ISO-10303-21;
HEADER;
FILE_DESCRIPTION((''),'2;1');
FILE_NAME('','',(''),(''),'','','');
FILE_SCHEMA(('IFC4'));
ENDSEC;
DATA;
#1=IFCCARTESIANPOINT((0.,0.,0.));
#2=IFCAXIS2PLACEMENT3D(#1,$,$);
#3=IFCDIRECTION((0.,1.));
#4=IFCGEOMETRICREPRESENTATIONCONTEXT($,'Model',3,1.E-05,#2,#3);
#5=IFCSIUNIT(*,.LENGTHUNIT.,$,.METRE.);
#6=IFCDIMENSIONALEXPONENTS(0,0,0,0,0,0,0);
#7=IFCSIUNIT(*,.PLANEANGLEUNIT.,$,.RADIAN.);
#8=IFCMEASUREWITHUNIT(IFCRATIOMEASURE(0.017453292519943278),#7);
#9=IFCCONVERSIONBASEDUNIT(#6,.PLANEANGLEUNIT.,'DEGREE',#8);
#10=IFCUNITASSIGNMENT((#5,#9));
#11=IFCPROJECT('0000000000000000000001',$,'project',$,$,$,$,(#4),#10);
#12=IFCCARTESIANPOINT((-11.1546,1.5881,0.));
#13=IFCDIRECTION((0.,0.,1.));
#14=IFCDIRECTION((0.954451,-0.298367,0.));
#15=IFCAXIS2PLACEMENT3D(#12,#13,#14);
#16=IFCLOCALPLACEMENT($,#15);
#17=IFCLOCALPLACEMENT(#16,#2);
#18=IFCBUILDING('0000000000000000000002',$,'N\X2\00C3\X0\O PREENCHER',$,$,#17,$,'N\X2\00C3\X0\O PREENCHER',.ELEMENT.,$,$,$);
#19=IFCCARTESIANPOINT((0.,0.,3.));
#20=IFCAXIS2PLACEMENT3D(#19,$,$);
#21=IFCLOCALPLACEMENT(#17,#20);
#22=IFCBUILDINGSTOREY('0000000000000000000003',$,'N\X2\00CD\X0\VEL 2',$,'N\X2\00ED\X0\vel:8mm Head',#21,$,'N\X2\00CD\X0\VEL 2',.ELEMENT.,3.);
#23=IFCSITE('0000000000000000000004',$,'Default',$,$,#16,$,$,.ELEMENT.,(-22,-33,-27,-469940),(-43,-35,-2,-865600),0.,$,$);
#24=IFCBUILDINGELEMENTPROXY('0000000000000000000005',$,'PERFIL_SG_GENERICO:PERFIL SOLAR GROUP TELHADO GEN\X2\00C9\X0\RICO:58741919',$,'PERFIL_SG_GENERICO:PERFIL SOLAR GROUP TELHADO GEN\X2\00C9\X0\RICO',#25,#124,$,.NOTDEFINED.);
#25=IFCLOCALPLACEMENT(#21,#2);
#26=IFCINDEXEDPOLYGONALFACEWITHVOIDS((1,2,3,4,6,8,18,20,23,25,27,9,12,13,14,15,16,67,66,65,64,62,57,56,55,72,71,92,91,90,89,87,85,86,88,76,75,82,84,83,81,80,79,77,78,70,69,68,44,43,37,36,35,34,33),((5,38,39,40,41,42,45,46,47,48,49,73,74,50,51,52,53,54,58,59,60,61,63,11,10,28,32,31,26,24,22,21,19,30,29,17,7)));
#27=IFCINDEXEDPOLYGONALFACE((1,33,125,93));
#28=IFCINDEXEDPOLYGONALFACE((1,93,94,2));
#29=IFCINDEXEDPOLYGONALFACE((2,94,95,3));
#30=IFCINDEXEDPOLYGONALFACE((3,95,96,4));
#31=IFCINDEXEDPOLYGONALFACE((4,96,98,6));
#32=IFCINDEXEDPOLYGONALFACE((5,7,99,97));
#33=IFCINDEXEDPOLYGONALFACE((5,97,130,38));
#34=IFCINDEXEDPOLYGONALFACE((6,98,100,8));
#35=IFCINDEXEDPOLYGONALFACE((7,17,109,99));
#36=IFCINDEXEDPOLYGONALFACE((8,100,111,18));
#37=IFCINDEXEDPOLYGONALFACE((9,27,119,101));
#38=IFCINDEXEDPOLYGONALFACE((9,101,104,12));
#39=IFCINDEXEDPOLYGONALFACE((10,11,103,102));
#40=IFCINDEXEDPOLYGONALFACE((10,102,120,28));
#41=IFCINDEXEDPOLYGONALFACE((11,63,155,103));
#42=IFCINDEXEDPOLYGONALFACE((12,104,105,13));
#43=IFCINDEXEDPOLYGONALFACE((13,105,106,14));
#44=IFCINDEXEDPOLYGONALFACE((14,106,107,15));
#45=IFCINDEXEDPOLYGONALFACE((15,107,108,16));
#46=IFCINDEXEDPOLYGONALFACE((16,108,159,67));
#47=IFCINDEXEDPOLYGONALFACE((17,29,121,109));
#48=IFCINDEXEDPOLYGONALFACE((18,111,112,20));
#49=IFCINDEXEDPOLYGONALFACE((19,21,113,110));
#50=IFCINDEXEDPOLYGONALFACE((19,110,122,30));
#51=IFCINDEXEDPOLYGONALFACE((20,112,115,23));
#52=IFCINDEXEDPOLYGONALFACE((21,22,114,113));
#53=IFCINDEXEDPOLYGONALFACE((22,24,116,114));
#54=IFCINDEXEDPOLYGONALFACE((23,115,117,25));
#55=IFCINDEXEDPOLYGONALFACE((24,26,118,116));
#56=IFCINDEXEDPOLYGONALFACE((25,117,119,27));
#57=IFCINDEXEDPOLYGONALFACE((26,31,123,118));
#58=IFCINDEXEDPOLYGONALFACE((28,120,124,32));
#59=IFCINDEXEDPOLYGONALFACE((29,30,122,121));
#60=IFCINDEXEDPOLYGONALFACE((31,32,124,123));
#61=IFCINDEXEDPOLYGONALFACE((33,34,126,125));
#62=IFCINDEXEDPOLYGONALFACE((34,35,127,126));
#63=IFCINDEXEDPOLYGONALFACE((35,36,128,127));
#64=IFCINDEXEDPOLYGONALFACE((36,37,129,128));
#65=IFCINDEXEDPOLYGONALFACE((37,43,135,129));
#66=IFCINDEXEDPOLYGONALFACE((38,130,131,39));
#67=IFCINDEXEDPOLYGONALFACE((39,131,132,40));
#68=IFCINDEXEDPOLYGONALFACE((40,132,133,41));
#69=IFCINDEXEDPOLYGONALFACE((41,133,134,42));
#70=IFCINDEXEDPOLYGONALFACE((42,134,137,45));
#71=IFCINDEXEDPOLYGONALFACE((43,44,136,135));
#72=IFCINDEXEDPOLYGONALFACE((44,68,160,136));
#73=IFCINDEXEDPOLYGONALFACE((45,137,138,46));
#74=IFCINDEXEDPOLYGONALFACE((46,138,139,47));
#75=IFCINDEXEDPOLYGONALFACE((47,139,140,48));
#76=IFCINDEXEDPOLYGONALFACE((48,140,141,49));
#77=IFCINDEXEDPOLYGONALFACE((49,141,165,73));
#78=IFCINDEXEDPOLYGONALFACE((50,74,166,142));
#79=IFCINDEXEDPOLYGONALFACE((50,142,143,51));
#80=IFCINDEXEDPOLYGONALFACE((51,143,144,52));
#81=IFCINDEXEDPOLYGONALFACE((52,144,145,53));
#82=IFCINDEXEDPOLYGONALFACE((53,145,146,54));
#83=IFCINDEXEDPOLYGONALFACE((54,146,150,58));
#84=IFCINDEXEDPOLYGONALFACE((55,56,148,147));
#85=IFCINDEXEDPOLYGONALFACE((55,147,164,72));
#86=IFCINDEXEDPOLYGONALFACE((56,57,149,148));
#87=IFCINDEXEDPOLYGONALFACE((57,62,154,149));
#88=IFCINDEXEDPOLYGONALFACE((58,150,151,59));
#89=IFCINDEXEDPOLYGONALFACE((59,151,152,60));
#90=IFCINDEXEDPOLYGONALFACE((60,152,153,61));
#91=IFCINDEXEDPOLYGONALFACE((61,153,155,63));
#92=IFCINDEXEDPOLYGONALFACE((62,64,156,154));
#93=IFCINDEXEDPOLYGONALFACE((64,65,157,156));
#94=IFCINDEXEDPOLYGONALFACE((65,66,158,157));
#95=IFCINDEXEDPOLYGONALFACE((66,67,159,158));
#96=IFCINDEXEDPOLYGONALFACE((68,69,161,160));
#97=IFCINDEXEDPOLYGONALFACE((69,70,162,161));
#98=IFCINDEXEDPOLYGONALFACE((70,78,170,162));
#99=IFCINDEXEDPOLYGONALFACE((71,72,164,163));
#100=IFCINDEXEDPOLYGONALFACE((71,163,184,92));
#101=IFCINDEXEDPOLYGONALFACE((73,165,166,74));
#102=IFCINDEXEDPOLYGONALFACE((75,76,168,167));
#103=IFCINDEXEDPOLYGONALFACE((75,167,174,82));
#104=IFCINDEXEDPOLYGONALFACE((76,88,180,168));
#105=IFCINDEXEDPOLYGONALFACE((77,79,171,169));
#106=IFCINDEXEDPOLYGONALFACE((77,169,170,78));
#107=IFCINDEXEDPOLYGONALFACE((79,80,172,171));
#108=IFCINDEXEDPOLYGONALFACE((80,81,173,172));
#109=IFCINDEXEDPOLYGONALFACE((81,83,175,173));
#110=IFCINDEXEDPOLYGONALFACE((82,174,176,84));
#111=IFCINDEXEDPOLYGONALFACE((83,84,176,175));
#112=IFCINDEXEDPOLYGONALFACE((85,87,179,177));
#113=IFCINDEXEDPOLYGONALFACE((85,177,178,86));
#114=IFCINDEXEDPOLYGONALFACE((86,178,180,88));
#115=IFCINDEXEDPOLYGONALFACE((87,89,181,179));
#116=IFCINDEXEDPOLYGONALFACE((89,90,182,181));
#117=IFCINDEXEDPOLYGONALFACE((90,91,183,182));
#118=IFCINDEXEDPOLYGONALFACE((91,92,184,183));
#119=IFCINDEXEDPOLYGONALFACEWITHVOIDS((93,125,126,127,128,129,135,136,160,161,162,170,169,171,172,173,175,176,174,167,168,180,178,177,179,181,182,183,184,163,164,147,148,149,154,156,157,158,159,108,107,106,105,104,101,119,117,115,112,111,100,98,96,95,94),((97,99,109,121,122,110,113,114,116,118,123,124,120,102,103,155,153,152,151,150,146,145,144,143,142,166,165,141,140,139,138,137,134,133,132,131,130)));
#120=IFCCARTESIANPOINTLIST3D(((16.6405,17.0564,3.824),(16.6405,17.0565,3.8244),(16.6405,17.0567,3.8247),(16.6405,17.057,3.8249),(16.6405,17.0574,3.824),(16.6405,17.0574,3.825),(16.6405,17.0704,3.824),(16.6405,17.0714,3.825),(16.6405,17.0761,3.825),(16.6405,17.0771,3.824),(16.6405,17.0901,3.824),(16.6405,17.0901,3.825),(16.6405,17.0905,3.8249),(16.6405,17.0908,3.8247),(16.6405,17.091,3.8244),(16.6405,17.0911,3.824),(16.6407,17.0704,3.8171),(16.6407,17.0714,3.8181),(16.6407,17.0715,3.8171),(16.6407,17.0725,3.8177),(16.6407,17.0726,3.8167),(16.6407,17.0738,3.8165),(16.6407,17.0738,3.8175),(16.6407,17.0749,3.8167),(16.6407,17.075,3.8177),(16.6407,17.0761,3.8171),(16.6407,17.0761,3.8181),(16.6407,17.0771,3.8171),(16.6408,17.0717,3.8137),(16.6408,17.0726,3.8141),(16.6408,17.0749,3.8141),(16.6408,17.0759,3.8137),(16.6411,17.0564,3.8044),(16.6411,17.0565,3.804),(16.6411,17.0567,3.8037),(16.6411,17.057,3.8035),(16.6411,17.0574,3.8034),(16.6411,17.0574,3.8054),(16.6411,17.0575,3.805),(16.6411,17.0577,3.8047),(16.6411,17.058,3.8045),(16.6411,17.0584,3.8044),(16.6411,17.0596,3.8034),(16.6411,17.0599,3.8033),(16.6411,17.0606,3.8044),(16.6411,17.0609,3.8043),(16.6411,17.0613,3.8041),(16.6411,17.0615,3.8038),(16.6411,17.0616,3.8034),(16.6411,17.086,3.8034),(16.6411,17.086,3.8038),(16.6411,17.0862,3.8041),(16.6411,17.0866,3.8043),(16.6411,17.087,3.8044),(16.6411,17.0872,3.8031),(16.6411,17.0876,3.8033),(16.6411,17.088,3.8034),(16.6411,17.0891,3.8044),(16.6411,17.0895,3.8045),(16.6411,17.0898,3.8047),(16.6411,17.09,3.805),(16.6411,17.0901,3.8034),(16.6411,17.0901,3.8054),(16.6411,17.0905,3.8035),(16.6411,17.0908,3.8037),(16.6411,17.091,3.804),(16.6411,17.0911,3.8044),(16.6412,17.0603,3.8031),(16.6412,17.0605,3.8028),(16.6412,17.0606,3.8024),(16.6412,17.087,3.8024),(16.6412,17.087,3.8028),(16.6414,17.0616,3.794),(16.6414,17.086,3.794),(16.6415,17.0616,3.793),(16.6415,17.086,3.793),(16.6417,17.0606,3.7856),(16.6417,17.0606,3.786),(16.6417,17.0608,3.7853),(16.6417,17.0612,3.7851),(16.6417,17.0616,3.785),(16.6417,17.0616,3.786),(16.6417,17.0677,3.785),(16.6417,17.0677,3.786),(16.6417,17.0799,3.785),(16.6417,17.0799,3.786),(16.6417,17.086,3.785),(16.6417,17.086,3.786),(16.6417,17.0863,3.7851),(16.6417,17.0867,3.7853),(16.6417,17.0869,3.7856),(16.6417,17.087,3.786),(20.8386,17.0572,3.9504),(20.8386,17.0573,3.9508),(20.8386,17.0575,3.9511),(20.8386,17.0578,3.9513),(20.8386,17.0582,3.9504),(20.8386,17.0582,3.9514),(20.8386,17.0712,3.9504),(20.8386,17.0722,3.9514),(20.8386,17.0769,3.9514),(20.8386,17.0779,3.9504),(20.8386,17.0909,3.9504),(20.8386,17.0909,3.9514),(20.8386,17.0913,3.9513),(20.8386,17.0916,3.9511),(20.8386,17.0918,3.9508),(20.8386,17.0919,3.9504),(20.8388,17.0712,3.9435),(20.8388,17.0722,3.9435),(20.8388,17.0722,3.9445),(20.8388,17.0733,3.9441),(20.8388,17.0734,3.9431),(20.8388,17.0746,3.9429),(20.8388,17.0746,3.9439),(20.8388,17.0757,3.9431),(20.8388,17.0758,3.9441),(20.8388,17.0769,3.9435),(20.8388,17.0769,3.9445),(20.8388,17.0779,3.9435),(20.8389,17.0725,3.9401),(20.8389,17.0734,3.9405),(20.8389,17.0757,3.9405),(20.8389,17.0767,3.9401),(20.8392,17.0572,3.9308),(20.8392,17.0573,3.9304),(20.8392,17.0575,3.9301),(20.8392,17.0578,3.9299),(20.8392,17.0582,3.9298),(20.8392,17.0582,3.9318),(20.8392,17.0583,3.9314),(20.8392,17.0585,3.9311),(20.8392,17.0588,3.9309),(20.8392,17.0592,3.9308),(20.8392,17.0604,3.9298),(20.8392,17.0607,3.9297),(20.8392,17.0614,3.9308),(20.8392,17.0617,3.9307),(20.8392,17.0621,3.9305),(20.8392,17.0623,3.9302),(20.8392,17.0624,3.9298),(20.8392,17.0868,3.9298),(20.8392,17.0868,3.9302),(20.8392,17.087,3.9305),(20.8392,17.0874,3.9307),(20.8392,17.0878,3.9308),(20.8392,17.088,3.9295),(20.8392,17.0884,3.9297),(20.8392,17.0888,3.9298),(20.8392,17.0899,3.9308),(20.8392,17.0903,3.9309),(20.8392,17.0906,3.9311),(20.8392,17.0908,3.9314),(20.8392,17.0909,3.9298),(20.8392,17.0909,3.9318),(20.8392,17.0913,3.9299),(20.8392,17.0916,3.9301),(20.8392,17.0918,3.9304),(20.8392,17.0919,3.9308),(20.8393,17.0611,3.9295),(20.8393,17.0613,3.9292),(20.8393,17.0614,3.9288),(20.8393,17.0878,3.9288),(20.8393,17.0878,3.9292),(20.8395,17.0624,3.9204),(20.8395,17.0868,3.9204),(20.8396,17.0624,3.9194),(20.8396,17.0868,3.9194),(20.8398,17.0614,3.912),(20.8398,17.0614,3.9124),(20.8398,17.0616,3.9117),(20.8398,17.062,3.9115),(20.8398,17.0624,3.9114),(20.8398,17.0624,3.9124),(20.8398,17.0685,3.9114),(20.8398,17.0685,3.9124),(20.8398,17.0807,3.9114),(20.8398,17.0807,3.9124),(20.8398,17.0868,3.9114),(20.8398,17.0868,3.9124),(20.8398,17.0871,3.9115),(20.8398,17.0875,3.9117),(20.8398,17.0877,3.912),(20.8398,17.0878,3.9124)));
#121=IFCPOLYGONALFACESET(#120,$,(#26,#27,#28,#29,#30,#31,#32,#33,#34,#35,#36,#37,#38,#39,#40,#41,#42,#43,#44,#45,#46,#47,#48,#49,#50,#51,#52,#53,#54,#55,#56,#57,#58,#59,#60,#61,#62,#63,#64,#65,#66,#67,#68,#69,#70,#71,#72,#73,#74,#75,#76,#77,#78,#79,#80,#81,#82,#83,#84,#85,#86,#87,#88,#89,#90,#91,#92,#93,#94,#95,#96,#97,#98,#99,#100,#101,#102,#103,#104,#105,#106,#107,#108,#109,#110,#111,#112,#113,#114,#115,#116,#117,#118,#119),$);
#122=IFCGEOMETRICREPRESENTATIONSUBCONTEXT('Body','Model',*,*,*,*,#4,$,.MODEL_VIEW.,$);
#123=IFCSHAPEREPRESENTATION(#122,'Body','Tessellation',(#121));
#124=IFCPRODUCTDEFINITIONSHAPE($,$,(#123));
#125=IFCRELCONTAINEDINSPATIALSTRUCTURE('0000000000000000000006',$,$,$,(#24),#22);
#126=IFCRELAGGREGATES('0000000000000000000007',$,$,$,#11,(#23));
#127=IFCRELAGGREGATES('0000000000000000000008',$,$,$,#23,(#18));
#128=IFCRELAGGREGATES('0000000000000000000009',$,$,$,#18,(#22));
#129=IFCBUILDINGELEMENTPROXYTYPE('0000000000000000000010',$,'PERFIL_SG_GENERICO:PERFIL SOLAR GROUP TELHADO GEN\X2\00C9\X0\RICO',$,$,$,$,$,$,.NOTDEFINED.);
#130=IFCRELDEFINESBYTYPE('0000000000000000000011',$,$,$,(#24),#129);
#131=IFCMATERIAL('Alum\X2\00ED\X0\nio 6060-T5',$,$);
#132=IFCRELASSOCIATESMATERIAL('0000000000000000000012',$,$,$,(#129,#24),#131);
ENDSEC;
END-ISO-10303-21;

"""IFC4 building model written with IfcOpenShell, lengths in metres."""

from ifc_helpers import new_model, entity, si_unit, converted_unit, direction, frame, origin, place, context, subcontext, project, spatial, line, arc, indexed_curve, outline, extrude, source, transform, mapped, material, type_object, type_shapes, element, save


model = new_model("IFC4")

# Units and contexts
model_context = context("Model", 3, precision=1e-05, world=origin(), true_north=direction((0.0, 1.0)))
body_context = subcontext(model_context, "Body", "Model", "MODEL_VIEW")
ifc_project = project(units=[si_unit("LENGTHUNIT", "METRE"), converted_unit("PLANEANGLEUNIT", "DEGREE", entity("IfcRatioMeasure", 0.017453292519943278), si_unit("PLANEANGLEUNIT", "RADIAN"), dimensions=[0, 0, 0, 0, 0, 0, 0])], contexts=[model_context])

# Site, building, storey
site_placement = place(None, frame((-11.1546, 1.5881, 0.0), z_axis=(0.0, 0.0, 1.0), x_axis=(0.954451, -0.298367, 0.0)))
site = spatial("IfcSite", under=ifc_project, at=site_placement, Name="Default", CompositionType="ELEMENT", RefLatitude=(-22, -33, -27, -469940), RefLongitude=(-43, -35, -2, -865600), RefElevation=0.0)
building_placement = place(site_placement, origin())
building = spatial("IfcBuilding", under=site, at=building_placement, Name="NÃO PREENCHER", LongName="NÃO PREENCHER", CompositionType="ELEMENT")
storey_placement = place(building_placement, frame((0.0, 0.0, 3.0)))
storey = spatial("IfcBuildingStorey", under=building, at=storey_placement, Name="NÍVEL 2", ObjectType="Nível:8mm Head", LongName="NÍVEL 2", CompositionType="ELEMENT", Elevation=3.0)

# Building element proxy
ifc_material_1 = material(Name="Alumínio 6060-T5")
building_element_proxy_type_1 = type_object("IfcBuildingElementProxyType", Name="PERFIL_SG_GENERICO:PERFIL SOLAR GROUP TELHADO GENÉRICO", PredefinedType="NOTDEFINED", material=ifc_material_1)
shared_shape_1 = source(origin(), body_context, "Body", "SweptSolid", [
    extrude(outline(indexed_curve([(-0.0122, -0.0169), (-0.0061, -0.0169), (-0.0061, -0.0159), (-0.0122, -0.0159), (-0.0122, -0.0089), (0.0122, -0.0089), (0.0122, -0.0159), (0.0061, -0.0159), (0.0061, -0.0169), (0.0122, -0.0169), (0.0129, -0.0166), (0.0132, -0.0159), (0.0132, 0.0005), (0.0135, 0.0012), (0.0142, 0.0015), (0.0164, 0.0015), (0.0171, 0.0018), (0.0174, 0.0025), (0.0174, 0.0221), (0.0171, 0.0228), (0.0164, 0.0231), (0.0024, 0.0231), (0.0024, 0.0162), (0.0, 0.0156), (-0.0024, 0.0162), (-0.0024, 0.0231), (-0.0164, 0.0231), (-0.0171, 0.0228), (-0.0174, 0.0221), (-0.0174, 0.0025), (-0.0171, 0.0018), (-0.0164, 0.0015), (-0.0142, 0.0015), (-0.0135, 0.0012), (-0.0132, 0.0005), (-0.0132, -0.0159), (-0.0129, -0.0166)], segments=[line(1, 2, 3, 4, 5, 6, 7, 8, 9, 10), arc(10, 11, 12), line(12, 13), arc(13, 14, 15), line(15, 16), arc(16, 17, 18), line(18, 19), arc(19, 20, 21), line(21, 22, 23), arc(23, 24, 25), line(25, 26, 27), arc(27, 28, 29), line(29, 30), arc(30, 31, 32), line(32, 33), arc(33, 34, 35), line(35, 36), arc(36, 37, 1)], self_intersect=False), holes=[indexed_curve([(-0.0122, -0.0079), (-0.0122, 0.0015), (-0.0125, 0.0022), (-0.0132, 0.0025), (-0.0154, 0.0025), (-0.0161, 0.0028), (-0.0164, 0.0035), (-0.0164, 0.0221), (-0.0034, 0.0221), (-0.0034, 0.0152), (-0.0021, 0.0118), (-0.0012, 0.0122), (-0.0023, 0.0151), (0.0, 0.0146), (0.0023, 0.0151), (0.0012, 0.0122), (0.0021, 0.0118), (0.0034, 0.0152), (0.0034, 0.0221), (0.0164, 0.0221), (0.0164, 0.0035), (0.0161, 0.0028), (0.0154, 0.0025), (0.0132, 0.0025), (0.0125, 0.0022), (0.0122, 0.0015), (0.0122, -0.0079)], segments=[line(1, 2), arc(2, 3, 4), line(4, 5), arc(5, 6, 7), line(7, 8, 9, 10, 11, 12, 13), arc(13, 14, 15), line(15, 16, 17, 18, 19, 20, 21), arc(21, 22, 23), line(23, 24), arc(24, 25, 26), line(26, 27, 1)], self_intersect=False)]), frame((0.0, 0.0, 0.0169), z_axis=(1.0, 0.0, 0.0), x_axis=(0.0, 1.0, 0.0)), (0.0, 0.0, 1.0), 4.2),
])
type_shapes(building_element_proxy_type_1, [shared_shape_1])
for number, where, z_axis, x_axis, name in (
    (1, (16.6417, 17.0738, 3.785), (-0.030095, 0.0, 0.999547), (0.999547, 0.00019, 0.030095), "PERFIL_SG_GENERICO:PERFIL SOLAR GROUP TELHADO GENÉRICO:58741919"),
):
    element("IfcBuildingElementProxy", number, at=place(storey_placement, frame(where, z_axis=z_axis, x_axis=x_axis)), inside=storey, type_object=building_element_proxy_type_1, material=ifc_material_1, Name=name, ObjectType="PERFIL_SG_GENERICO:PERFIL SOLAR GROUP TELHADO GENÉRICO", PredefinedType="NOTDEFINED", context=body_context, shape_type="MappedRepresentation", body=[
        mapped(shared_shape_1, transform((0.0, 0.0, 0.0), scale=1.0)),
    ])

save(model, "model.ifc")
